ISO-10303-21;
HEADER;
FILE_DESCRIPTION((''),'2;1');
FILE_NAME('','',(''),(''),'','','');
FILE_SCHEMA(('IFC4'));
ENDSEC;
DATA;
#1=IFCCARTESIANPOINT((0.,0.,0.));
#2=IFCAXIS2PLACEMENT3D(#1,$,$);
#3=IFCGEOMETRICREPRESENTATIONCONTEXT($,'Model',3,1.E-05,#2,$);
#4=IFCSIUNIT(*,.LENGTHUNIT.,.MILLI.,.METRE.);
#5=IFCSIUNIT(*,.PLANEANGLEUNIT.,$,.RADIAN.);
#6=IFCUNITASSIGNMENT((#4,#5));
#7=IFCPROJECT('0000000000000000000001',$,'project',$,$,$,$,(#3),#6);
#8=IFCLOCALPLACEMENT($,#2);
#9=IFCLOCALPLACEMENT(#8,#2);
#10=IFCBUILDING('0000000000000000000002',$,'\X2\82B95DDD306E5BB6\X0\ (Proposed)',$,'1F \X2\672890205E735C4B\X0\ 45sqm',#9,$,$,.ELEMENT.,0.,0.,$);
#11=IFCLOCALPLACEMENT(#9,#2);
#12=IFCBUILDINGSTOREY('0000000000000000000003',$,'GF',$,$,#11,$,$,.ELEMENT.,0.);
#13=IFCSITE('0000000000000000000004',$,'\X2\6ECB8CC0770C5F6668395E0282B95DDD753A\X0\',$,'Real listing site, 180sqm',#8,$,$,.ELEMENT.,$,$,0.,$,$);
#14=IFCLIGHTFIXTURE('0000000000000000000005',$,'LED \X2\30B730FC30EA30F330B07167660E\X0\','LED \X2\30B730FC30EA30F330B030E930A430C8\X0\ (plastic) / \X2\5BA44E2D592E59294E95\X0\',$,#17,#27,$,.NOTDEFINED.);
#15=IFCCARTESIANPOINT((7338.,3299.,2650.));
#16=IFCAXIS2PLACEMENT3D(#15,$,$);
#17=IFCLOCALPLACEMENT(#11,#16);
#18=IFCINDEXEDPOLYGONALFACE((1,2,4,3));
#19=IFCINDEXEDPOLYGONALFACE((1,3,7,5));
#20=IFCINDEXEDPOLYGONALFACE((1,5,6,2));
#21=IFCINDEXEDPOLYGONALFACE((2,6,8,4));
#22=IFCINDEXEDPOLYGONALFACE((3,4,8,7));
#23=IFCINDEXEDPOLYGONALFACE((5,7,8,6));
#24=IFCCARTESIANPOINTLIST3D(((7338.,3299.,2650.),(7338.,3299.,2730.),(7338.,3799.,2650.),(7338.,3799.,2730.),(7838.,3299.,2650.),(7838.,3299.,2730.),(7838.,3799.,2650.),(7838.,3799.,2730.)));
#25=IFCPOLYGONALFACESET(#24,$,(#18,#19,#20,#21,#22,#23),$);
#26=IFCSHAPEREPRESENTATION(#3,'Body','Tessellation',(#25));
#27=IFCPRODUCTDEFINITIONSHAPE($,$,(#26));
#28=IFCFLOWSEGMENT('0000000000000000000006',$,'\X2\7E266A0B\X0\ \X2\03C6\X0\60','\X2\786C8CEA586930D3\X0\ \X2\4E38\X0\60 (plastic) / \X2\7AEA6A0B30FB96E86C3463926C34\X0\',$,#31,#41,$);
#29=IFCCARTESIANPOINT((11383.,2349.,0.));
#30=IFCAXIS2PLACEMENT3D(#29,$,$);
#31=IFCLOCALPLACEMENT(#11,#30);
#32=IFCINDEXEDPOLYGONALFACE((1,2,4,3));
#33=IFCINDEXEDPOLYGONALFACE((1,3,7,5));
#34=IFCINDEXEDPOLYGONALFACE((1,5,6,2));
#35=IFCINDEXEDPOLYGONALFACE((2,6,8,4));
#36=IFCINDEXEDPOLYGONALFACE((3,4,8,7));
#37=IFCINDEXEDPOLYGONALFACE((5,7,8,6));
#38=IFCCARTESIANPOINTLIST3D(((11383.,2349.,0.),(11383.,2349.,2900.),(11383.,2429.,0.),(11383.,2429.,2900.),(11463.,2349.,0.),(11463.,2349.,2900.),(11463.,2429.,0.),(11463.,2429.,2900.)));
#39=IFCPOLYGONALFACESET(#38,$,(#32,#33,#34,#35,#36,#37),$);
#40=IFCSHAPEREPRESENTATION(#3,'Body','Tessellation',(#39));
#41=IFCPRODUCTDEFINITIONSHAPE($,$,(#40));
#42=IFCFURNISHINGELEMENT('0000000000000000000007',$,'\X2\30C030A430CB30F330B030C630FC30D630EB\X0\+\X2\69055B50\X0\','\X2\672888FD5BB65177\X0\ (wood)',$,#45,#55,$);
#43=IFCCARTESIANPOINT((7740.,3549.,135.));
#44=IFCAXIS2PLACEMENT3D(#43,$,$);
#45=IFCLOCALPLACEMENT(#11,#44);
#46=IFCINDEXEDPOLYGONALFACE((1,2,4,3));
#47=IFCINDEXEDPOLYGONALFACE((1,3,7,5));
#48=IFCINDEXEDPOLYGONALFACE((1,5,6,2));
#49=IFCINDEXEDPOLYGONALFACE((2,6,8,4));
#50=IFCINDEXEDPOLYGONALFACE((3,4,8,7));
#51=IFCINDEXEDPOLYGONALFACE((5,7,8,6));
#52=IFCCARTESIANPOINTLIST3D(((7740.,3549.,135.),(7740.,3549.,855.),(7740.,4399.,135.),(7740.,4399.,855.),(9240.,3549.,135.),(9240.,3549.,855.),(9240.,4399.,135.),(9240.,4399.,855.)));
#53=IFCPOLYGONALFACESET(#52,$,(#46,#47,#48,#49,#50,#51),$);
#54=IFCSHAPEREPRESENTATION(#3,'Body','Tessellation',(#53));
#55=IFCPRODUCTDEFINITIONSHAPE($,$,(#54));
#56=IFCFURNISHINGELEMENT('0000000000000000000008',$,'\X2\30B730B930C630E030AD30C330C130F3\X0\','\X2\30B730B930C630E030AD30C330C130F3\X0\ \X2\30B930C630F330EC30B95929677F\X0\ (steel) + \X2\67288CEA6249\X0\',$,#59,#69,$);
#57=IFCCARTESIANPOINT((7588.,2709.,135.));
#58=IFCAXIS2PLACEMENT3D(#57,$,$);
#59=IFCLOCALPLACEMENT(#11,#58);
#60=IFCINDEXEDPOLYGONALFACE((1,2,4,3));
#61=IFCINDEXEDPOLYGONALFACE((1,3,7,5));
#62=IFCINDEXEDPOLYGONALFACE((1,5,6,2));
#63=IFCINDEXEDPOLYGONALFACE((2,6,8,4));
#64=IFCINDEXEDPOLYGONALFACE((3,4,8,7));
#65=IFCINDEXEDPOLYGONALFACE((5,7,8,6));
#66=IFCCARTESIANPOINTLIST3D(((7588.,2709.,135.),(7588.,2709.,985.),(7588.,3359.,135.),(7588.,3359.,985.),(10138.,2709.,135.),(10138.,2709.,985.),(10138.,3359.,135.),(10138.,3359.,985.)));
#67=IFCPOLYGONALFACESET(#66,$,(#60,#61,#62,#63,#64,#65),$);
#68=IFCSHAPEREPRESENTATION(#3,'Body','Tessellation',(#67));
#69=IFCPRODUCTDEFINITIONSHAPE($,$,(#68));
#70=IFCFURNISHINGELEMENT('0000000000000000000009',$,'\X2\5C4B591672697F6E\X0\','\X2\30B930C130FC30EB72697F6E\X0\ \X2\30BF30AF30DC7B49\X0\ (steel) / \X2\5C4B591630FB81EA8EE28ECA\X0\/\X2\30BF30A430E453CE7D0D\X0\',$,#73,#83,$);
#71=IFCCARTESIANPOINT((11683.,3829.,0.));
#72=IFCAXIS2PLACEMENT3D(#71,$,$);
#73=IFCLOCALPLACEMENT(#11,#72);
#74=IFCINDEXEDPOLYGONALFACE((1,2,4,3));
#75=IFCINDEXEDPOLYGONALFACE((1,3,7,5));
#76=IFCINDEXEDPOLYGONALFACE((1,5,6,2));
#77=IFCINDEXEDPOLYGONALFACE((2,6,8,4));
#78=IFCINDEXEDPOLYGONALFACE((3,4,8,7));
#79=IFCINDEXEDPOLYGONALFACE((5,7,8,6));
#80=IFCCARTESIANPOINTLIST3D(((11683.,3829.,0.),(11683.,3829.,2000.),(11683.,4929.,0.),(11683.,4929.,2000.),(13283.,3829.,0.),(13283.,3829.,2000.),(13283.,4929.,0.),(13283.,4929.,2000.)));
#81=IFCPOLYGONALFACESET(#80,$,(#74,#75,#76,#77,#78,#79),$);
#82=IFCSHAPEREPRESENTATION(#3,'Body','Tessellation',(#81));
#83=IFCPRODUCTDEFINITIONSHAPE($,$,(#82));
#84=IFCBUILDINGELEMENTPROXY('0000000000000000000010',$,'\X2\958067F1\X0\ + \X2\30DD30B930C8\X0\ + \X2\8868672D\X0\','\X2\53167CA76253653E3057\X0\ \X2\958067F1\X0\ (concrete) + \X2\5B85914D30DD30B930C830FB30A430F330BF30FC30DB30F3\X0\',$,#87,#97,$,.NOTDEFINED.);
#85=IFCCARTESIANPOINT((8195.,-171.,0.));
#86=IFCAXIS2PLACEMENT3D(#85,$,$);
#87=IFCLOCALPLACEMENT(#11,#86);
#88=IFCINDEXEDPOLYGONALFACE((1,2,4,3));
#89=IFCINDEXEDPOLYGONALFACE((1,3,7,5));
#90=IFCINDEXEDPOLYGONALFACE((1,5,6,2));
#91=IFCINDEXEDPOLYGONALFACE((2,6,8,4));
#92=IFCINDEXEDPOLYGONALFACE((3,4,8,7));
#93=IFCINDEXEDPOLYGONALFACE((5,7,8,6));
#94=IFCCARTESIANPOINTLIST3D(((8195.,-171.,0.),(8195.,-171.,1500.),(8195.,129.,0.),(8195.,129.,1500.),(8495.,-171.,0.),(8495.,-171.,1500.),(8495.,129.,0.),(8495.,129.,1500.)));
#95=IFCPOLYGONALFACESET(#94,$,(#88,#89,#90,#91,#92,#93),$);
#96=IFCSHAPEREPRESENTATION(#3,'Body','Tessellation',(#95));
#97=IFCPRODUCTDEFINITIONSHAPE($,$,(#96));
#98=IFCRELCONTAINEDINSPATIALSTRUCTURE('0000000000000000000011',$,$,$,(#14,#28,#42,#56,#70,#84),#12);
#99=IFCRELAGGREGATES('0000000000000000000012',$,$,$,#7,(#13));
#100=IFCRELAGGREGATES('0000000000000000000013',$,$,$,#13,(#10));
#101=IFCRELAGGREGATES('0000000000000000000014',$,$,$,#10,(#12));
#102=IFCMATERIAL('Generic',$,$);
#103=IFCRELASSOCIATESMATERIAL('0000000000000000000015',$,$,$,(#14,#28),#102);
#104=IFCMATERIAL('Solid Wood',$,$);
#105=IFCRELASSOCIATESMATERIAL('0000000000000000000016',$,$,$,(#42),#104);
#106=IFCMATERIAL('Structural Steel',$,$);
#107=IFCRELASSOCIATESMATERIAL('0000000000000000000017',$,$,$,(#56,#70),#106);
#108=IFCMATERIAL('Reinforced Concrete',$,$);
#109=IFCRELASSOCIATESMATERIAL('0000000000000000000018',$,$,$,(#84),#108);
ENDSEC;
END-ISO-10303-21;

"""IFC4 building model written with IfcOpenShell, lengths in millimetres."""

from ifc_helpers import new_model, si_unit, frame, frame_2d, origin, place, context, project, spatial, rectangle, extrude, material, element, save


model = new_model("IFC4")

# Units and contexts
model_context = context("Model", 3, precision=1e-05, world=origin())
ifc_project = project(units=[si_unit("LENGTHUNIT", "METRE", prefix="MILLI"), si_unit("PLANEANGLEUNIT", "RADIAN")], contexts=[model_context])

# Site, building, storey
site_placement = place(None, origin())
site = spatial("IfcSite", under=ifc_project, at=site_placement, Name="滋賀県彦根市芹川町", ObjectType="Real listing site, 180sqm", CompositionType="ELEMENT", RefElevation=0.0)
building_placement = place(site_placement, origin())
building = spatial("IfcBuilding", under=site, at=building_placement, Name="芹川の家 (Proposed)", ObjectType="1F 木造平屋 45sqm", CompositionType="ELEMENT", ElevationOfRefHeight=0.0, ElevationOfTerrain=0.0)
storey_placement = place(building_placement, origin())
storey = spatial("IfcBuildingStorey", under=building, at=storey_placement, Name="GF", CompositionType="ELEMENT", Elevation=0.0)

# Shared definitions
ifc_material_1 = material(Name="Solid Wood")

# Shared definitions
ifc_material_2 = material(Name="Structural Steel")

# Shared definitions
ifc_material_3 = material(Name="Reinforced Concrete")

# Shared definitions
ifc_material_4 = material(Name="Generic")

# Light fixture
light_fixture_placement = place(storey_placement, frame((7338.0, 3299.0, 2650.0)))
element("IfcLightFixture", 1, at=light_fixture_placement, inside=storey, material=ifc_material_4, Name="LED シーリング照明", Description="LED シーリングライト (plastic) / 室中央天井", PredefinedType="NOTDEFINED", context=model_context, shape_type="SweptSolid", body=[
    extrude(rectangle(XDim=500.0, YDim=500.0, at=frame_2d((250.0, 250.0))), frame((7338.0, 3299.0, 2650.0)), (0.0, 0.0, 1.0), 80.0),
])

# Flow segment
flow_segment_placement = place(storey_placement, frame((11383.0, 2349.0, 0.0)))
element("IfcFlowSegment", 2, at=flow_segment_placement, inside=storey, material=ifc_material_4, Name="縦樋 φ60", Description="硬質塩ビ 丸60 (plastic) / 竪樋・雨水排水", context=model_context, shape_type="SweptSolid", body=[
    extrude(rectangle(XDim=80.0, YDim=80.0, at=frame_2d((40.0, 40.0))), frame((11383.0, 2349.0, 0.0)), (0.0, 0.0, 1.0), 2900.0),
])

# Furnishing elements
furnishing_1_placement = place(storey_placement, frame((7740.0, 3549.0, 135.0)))
element("IfcFurnishingElement", 3, at=furnishing_1_placement, inside=storey, material=ifc_material_1, Name="ダイニングテーブル+椅子", Description="木製家具 (wood)", context=model_context, shape_type="SweptSolid", body=[
    extrude(rectangle(XDim=1500.0, YDim=850.0, at=frame_2d((750.0, 425.0))), frame((7740.0, 3549.0, 135.0)), (0.0, 0.0, 1.0), 720.0),
])
furnishing_2_placement = place(storey_placement, frame((7588.0, 2709.0, 135.0)))
element("IfcFurnishingElement", 4, at=furnishing_2_placement, inside=storey, material=ifc_material_2, Name="システムキッチン", Description="システムキッチン ステンレス天板 (steel) + 木質扉", context=model_context, shape_type="SweptSolid", body=[
    extrude(rectangle(XDim=2550.0, YDim=650.0, at=frame_2d((1275.0, 325.0))), frame((7588.0, 2709.0, 135.0)), (0.0, 0.0, 1.0), 850.0),
])
furnishing_3_placement = place(storey_placement, frame((11683.0, 3829.0, 0.0)))
element("IfcFurnishingElement", 5, at=furnishing_3_placement, inside=storey, material=ifc_material_2, Name="屋外物置", Description="スチール物置 タクボ等 (steel) / 屋外・自転車/タイヤ収納", context=model_context, shape_type="SweptSolid", body=[
    extrude(rectangle(XDim=1600.0, YDim=1100.0, at=frame_2d((800.0, 550.0))), frame((11683.0, 3829.0, 0.0)), (0.0, 0.0, 1.0), 2000.0),
])

# Building element proxy
proxy_placement = place(storey_placement, frame((8195.0, -171.0, 0.0)))
element("IfcBuildingElementProxy", 6, at=proxy_placement, inside=storey, material=ifc_material_3, Name="門柱 + ポスト + 表札", Description="化粧打放し 門柱 (concrete) + 宅配ポスト・インターホン", PredefinedType="NOTDEFINED", context=model_context, shape_type="SweptSolid", body=[
    extrude(rectangle(XDim=300.0, YDim=300.0, at=frame_2d((150.0, 150.0))), frame((8195.0, -171.0, 0.0)), (0.0, 0.0, 1.0), 1500.0),
])

save(model, "model.ifc")
